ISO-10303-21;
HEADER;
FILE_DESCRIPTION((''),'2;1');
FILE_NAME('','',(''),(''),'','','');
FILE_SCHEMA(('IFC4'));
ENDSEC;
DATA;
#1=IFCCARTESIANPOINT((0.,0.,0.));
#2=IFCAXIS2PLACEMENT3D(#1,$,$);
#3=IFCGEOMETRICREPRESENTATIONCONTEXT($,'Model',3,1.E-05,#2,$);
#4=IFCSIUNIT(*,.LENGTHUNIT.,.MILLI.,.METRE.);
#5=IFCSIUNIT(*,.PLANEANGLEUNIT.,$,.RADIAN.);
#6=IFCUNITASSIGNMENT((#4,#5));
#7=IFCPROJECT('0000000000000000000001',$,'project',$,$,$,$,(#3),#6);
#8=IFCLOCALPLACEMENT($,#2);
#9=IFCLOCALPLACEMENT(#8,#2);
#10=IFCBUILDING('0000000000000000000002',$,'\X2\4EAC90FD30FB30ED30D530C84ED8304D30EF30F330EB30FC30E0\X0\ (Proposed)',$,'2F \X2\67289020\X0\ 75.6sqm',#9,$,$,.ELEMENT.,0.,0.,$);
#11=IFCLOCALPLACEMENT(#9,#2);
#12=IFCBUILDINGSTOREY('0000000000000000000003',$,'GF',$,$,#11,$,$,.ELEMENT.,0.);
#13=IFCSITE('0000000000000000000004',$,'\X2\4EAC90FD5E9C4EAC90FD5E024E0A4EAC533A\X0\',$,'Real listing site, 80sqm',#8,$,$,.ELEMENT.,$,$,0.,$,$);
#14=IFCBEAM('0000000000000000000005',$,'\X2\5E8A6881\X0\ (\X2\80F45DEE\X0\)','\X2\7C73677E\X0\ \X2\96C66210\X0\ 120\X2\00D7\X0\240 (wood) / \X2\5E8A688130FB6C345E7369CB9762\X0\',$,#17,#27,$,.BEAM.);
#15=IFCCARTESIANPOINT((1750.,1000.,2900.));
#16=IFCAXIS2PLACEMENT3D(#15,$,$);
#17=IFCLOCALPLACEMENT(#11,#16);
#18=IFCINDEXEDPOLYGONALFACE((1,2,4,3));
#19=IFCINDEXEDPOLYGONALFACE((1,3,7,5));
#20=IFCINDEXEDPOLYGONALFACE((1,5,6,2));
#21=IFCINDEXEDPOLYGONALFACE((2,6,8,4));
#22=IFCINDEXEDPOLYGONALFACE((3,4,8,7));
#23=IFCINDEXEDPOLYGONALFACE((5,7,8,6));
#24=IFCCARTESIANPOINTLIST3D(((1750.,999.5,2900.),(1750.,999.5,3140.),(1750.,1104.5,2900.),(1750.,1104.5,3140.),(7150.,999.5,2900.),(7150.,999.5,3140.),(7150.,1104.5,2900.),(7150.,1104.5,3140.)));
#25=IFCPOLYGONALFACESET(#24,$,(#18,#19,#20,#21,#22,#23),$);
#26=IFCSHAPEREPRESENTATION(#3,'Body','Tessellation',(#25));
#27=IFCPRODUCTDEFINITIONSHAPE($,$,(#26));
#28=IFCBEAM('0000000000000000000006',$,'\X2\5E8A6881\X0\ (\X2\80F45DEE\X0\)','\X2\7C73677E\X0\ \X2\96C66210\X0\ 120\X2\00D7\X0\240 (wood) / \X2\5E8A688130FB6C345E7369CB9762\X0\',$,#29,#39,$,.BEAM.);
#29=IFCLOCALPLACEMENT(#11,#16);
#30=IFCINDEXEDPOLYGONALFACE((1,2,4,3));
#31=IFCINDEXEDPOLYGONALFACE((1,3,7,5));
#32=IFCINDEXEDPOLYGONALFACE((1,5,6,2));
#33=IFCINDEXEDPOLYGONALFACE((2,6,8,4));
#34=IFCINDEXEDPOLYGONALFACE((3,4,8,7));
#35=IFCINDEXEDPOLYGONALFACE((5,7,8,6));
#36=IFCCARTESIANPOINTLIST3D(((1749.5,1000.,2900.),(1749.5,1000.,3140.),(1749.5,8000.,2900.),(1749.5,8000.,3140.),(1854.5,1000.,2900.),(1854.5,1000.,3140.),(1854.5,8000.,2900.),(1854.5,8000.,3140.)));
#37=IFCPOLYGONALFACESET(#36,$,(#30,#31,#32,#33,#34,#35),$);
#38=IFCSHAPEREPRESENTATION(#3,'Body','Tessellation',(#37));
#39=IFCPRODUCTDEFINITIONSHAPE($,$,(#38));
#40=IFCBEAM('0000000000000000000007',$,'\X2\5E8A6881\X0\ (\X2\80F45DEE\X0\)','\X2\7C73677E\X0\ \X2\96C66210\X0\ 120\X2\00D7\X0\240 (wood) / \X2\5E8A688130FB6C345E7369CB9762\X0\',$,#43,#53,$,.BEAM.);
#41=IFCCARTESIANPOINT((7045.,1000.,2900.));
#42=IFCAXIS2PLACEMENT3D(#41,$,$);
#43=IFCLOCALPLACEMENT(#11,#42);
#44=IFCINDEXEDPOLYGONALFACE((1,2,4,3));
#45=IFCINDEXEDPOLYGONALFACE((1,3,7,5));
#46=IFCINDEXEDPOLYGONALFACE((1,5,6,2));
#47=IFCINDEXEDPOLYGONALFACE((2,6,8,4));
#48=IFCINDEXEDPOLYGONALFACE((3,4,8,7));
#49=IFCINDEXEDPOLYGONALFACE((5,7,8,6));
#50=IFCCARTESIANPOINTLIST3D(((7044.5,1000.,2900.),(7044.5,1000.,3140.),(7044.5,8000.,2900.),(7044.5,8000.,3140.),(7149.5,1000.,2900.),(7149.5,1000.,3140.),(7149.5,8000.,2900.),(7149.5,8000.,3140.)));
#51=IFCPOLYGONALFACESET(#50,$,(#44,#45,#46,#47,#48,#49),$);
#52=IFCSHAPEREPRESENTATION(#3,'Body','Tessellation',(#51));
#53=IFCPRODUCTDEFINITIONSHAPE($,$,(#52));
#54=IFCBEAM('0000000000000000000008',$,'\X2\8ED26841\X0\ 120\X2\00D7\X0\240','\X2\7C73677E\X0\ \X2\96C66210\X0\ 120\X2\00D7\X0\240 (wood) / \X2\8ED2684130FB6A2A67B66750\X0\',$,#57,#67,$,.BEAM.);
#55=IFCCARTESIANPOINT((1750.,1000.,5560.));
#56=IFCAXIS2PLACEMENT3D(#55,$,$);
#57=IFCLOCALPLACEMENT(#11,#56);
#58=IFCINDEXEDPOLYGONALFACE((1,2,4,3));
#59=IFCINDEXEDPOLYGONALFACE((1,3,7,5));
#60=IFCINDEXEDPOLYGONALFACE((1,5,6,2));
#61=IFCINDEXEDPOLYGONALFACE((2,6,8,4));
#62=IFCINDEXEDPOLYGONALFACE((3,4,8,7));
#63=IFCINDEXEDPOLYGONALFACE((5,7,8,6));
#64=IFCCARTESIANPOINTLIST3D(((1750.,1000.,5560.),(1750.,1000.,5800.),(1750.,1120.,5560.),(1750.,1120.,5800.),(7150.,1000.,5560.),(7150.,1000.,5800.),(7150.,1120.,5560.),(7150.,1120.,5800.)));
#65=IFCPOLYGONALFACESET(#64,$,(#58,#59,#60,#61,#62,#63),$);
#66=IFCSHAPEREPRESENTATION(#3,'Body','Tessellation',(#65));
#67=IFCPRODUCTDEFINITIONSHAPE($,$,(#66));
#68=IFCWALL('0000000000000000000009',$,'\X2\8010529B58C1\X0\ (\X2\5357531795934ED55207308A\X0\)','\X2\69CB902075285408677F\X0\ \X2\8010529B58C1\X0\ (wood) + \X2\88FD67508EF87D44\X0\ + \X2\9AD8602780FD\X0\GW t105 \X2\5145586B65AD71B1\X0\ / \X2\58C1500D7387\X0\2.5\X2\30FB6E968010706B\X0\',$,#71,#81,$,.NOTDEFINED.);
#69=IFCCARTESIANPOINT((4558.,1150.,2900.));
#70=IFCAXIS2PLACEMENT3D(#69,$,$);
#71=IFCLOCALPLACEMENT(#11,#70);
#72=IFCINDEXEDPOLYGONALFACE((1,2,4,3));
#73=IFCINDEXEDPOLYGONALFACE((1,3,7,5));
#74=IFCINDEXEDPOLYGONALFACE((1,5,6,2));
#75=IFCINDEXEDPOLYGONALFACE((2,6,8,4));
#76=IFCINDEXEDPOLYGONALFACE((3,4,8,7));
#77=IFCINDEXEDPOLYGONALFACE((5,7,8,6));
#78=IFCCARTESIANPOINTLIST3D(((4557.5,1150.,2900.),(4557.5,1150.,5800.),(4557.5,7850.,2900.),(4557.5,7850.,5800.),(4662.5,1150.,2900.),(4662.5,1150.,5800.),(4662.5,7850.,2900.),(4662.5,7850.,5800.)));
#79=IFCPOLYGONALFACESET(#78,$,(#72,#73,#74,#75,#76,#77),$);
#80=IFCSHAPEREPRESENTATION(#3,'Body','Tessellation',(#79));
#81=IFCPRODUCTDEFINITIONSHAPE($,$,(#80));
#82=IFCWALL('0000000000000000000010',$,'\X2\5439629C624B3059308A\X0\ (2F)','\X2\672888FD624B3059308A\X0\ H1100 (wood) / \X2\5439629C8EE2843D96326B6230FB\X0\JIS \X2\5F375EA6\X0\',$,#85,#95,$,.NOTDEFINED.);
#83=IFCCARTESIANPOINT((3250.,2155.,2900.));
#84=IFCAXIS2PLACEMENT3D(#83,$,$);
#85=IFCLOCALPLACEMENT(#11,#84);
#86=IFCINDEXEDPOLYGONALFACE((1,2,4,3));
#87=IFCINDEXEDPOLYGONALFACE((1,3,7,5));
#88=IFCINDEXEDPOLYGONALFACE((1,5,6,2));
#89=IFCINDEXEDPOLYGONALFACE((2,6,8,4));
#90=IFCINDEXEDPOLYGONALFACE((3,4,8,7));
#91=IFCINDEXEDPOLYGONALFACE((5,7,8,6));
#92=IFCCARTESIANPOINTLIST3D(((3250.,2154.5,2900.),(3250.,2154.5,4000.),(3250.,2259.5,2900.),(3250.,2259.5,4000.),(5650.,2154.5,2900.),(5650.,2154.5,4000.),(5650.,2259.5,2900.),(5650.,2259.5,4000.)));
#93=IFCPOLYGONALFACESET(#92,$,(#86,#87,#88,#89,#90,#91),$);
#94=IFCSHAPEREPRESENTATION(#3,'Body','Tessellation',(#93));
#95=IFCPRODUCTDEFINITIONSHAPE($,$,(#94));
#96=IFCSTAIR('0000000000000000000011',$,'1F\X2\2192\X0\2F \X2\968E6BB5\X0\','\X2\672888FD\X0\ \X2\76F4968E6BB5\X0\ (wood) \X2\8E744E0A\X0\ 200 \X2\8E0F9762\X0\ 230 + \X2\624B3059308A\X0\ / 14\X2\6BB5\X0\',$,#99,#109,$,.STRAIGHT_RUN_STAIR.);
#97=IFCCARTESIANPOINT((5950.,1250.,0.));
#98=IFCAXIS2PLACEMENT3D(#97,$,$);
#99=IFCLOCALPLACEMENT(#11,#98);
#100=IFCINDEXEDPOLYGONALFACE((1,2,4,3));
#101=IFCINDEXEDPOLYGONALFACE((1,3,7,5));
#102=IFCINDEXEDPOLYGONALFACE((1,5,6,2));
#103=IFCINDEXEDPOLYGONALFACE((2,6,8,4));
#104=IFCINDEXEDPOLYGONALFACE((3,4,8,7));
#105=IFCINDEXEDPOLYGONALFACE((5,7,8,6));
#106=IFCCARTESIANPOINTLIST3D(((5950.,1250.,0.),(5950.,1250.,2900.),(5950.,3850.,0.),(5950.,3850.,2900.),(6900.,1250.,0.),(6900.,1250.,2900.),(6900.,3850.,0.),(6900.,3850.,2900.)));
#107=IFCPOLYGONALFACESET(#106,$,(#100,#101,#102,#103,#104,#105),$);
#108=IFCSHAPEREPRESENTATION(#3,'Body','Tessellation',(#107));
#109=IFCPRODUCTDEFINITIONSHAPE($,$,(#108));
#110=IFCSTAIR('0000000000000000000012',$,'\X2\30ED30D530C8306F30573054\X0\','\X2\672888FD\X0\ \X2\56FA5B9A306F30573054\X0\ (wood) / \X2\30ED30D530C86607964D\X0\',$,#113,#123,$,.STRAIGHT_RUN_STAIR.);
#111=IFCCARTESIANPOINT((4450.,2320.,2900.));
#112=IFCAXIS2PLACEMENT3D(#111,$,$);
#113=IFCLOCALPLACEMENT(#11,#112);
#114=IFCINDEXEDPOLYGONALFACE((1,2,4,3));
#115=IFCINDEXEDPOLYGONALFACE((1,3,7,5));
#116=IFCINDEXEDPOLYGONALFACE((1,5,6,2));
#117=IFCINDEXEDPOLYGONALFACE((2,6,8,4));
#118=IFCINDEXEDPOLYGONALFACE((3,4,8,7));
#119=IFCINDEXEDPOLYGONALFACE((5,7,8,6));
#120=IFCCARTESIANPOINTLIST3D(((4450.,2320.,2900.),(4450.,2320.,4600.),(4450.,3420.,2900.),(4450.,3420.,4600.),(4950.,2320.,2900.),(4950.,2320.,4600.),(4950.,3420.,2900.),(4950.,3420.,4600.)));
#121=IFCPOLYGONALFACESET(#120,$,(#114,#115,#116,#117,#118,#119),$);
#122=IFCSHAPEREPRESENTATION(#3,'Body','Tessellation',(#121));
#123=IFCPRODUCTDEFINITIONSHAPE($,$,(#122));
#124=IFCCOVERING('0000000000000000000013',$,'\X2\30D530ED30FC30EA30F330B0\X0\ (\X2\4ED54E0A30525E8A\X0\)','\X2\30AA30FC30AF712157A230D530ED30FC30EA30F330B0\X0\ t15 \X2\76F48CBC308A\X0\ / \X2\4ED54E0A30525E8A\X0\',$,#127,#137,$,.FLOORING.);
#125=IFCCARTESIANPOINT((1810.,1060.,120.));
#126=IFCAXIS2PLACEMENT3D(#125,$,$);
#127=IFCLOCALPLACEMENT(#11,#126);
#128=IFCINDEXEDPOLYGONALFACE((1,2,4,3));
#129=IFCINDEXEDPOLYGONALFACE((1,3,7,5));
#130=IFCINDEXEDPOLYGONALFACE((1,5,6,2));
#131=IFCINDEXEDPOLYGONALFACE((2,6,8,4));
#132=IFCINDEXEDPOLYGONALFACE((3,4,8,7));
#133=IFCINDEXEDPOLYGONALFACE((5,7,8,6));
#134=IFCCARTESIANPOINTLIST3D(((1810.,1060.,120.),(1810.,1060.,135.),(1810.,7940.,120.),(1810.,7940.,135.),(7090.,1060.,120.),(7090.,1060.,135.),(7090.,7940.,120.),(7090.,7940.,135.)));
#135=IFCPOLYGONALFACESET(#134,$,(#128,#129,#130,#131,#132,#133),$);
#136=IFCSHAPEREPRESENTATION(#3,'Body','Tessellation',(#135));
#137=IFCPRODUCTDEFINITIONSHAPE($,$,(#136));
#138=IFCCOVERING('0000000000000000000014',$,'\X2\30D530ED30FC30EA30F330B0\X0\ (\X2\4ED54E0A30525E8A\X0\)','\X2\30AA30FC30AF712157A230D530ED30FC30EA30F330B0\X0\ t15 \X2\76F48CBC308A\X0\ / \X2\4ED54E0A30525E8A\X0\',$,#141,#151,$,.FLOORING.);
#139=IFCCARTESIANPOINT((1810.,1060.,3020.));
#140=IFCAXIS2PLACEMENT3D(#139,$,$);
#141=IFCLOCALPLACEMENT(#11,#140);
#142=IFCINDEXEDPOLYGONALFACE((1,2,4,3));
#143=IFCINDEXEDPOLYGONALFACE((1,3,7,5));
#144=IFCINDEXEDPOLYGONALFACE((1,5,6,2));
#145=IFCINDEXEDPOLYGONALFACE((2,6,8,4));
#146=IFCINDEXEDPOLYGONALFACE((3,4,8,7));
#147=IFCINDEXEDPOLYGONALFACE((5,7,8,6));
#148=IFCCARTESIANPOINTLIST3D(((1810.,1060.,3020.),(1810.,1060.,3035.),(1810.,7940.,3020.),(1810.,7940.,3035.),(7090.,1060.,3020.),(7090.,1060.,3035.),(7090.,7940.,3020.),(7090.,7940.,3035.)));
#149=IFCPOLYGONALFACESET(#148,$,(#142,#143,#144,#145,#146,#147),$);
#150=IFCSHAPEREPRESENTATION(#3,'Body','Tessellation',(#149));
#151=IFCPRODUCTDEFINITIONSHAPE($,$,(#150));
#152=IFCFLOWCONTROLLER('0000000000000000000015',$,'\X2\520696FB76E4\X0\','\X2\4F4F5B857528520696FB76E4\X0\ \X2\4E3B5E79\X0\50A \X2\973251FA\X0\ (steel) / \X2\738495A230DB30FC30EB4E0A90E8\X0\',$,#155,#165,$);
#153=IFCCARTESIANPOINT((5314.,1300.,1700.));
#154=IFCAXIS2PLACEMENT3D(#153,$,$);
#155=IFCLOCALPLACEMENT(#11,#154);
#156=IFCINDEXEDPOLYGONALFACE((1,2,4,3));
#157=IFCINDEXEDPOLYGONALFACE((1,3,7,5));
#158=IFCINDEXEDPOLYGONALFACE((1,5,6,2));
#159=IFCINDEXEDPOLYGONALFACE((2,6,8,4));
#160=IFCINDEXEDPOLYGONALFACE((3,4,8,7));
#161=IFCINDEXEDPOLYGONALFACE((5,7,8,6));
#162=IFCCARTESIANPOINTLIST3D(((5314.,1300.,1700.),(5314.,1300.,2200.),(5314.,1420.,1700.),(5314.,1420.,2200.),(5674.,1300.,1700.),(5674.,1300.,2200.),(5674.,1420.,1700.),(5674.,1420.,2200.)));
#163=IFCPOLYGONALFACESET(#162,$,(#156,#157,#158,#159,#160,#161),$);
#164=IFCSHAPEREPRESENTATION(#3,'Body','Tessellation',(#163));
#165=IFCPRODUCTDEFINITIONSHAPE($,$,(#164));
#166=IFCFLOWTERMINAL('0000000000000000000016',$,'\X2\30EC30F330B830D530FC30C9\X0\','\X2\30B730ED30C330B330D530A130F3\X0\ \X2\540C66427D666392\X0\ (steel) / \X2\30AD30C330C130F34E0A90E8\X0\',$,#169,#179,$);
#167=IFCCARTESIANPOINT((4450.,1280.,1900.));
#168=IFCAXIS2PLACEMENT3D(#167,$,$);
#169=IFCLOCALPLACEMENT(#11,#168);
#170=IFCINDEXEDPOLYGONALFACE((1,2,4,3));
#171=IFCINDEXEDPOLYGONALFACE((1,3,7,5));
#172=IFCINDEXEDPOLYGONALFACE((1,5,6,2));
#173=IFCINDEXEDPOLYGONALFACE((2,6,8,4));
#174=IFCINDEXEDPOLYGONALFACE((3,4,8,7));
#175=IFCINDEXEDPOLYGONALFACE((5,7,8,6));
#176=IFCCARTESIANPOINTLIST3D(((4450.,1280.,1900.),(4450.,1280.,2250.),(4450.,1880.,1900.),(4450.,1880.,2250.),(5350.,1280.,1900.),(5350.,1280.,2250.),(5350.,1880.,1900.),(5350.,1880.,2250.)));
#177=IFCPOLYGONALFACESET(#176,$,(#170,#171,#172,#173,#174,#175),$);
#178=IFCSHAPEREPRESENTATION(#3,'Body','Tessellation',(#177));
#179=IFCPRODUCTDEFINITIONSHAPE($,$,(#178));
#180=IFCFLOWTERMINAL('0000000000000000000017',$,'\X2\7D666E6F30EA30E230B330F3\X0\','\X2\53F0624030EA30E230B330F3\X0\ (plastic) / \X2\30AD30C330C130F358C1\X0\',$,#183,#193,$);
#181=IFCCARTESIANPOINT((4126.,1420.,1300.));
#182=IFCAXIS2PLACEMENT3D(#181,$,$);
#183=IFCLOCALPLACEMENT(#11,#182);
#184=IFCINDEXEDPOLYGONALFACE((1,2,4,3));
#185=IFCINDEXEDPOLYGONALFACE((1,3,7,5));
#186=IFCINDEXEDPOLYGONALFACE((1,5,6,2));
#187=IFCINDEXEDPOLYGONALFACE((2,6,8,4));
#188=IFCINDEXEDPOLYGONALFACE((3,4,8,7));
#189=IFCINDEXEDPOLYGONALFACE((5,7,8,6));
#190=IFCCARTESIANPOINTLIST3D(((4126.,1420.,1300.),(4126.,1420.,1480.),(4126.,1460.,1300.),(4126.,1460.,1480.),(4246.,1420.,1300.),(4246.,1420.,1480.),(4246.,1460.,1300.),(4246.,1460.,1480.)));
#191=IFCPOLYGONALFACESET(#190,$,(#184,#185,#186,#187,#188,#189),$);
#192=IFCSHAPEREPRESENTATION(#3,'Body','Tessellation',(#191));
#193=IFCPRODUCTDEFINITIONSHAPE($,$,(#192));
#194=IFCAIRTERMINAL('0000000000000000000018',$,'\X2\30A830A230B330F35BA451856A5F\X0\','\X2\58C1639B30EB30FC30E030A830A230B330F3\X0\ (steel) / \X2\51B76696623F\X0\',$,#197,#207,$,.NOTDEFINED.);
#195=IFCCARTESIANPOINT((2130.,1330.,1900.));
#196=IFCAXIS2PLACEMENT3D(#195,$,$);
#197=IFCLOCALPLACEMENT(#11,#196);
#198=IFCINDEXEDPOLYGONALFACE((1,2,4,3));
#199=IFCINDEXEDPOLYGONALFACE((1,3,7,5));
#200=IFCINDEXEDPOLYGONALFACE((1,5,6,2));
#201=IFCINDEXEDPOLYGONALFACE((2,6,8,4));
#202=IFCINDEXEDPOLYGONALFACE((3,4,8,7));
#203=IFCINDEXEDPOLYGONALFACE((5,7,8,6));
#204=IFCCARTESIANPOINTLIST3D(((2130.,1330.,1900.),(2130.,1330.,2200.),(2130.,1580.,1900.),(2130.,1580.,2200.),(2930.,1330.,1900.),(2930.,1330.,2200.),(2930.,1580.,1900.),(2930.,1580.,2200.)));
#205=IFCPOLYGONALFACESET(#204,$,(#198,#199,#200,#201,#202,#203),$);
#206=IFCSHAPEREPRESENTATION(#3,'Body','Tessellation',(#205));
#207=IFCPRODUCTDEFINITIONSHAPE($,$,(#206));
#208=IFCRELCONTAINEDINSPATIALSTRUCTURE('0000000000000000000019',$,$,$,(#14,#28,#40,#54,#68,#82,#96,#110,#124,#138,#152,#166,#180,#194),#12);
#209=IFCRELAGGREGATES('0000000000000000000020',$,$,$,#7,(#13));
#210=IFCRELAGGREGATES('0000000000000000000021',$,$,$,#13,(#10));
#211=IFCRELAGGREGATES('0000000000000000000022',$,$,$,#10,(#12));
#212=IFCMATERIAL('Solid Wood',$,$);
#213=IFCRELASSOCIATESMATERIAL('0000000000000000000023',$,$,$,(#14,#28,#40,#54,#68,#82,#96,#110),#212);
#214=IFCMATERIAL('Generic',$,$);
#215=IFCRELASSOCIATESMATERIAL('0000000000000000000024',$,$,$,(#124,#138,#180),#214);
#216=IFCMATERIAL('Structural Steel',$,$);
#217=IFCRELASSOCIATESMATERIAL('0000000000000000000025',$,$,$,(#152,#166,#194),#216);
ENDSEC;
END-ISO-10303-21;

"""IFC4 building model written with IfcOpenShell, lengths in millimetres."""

from ifc_helpers import new_model, si_unit, frame, frame_2d, origin, place, context, project, spatial, rectangle, extrude, material, element, save


model = new_model("IFC4")

# Units and contexts
model_context = context("Model", 3, precision=1e-05, world=origin())
ifc_project = project(units=[si_unit("LENGTHUNIT", "METRE", prefix="MILLI"), si_unit("PLANEANGLEUNIT", "RADIAN")], contexts=[model_context])

# Site, building, storey
site_placement = place(None, origin())
site = spatial("IfcSite", under=ifc_project, at=site_placement, Name="京都府京都市上京区", ObjectType="Real listing site, 80sqm", CompositionType="ELEMENT", RefElevation=0.0)
building_placement = place(site_placement, origin())
building = spatial("IfcBuilding", under=site, at=building_placement, Name="京都・ロフト付きワンルーム (Proposed)", ObjectType="2F 木造 75.6sqm", CompositionType="ELEMENT", ElevationOfRefHeight=0.0, ElevationOfTerrain=0.0)
storey_placement = place(building_placement, origin())
storey = spatial("IfcBuildingStorey", under=building, at=storey_placement, Name="GF", CompositionType="ELEMENT", Elevation=0.0)

# Beams
ifc_material_1 = material(Name="Solid Wood")
beam_1_placement = place(storey_placement, frame((1750.0, 1000.0, 2900.0)))
element("IfcBeam", 1, at=beam_1_placement, inside=storey, material=ifc_material_1, Name="床梁 (胴差)", Description="米松 集成 120×240 (wood) / 床梁・水平構面", PredefinedType="BEAM", context=model_context, shape_type="SweptSolid", body=[
    extrude(rectangle(XDim=5400.0, YDim=105.0, at=frame_2d((2700.0, 52.0))), frame((1750.0, 1000.0, 2900.0)), (0.0, 0.0, 1.0), 240.0),
])
beam_2_placement = place(storey_placement, frame((1750.0, 1000.0, 2900.0)))
element("IfcBeam", 2, at=beam_2_placement, inside=storey, material=ifc_material_1, Name="床梁 (胴差)", Description="米松 集成 120×240 (wood) / 床梁・水平構面", PredefinedType="BEAM", context=model_context, shape_type="SweptSolid", body=[
    extrude(rectangle(XDim=105.0, YDim=7000.0, at=frame_2d((52.0, 3500.0))), frame((1750.0, 1000.0, 2900.0)), (0.0, 0.0, 1.0), 240.0),
])
beam_3_placement = place(storey_placement, frame((7045.0, 1000.0, 2900.0)))
element("IfcBeam", 3, at=beam_3_placement, inside=storey, material=ifc_material_1, Name="床梁 (胴差)", Description="米松 集成 120×240 (wood) / 床梁・水平構面", PredefinedType="BEAM", context=model_context, shape_type="SweptSolid", body=[
    extrude(rectangle(XDim=105.0, YDim=7000.0, at=frame_2d((52.0, 3500.0))), frame((7045.0, 1000.0, 2900.0)), (0.0, 0.0, 1.0), 240.0),
])
beam_4_placement = place(storey_placement, frame((1750.0, 1000.0, 5560.0)))
element("IfcBeam", 4, at=beam_4_placement, inside=storey, material=ifc_material_1, Name="軒桁 120×240", Description="米松 集成 120×240 (wood) / 軒桁・横架材", PredefinedType="BEAM", context=model_context, shape_type="SweptSolid", body=[
    extrude(rectangle(XDim=5400.0, YDim=120.0, at=frame_2d((2700.0, 60.0))), frame((1750.0, 1000.0, 5560.0)), (0.0, 0.0, 1.0), 240.0),
])

# Walls
wall_1_placement = place(storey_placement, frame((4558.0, 1150.0, 2900.0)))
element("IfcWall", 5, at=wall_1_placement, inside=storey, material=ifc_material_1, Name="耐力壁 (南北間仕切り)", Description="構造用合板 耐力壁 (wood) + 製材軸組 + 高性能GW t105 充填断熱 / 壁倍率2.5・準耐火", PredefinedType="NOTDEFINED", context=model_context, shape_type="SweptSolid", body=[
    extrude(rectangle(XDim=105.0, YDim=6700.0, at=frame_2d((52.0, 3350.0))), frame((4558.0, 1150.0, 2900.0)), (0.0, 0.0, 1.0), 2900.0),
])
wall_2_placement = place(storey_placement, frame((3250.0, 2155.0, 2900.0)))
element("IfcWall", 6, at=wall_2_placement, inside=storey, material=ifc_material_1, Name="吹抜手すり (2F)", Description="木製手すり H1100 (wood) / 吹抜転落防止・JIS 強度", PredefinedType="NOTDEFINED", context=model_context, shape_type="SweptSolid", body=[
    extrude(rectangle(XDim=2400.0, YDim=105.0, at=frame_2d((1200.0, 52.0))), frame((3250.0, 2155.0, 2900.0)), (0.0, 0.0, 1.0), 1100.0),
])

# Stairs
stair_1_placement = place(storey_placement, frame((5950.0, 1250.0, 0.0)))
element("IfcStair", 7, at=stair_1_placement, inside=storey, material=ifc_material_1, Name="1F→2F 階段", Description="木製 直階段 (wood) 蹴上 200 踏面 230 + 手すり / 14段", PredefinedType="STRAIGHT_RUN_STAIR", context=model_context, shape_type="SweptSolid", body=[
    extrude(rectangle(XDim=950.0, YDim=2600.0, at=frame_2d((475.0, 1300.0))), frame((5950.0, 1250.0, 0.0)), (0.0, 0.0, 1.0), 2900.0),
])
stair_2_placement = place(storey_placement, frame((4450.0, 2320.0, 2900.0)))
element("IfcStair", 8, at=stair_2_placement, inside=storey, material=ifc_material_1, Name="ロフトはしご", Description="木製 固定はしご (wood) / ロフト昇降", PredefinedType="STRAIGHT_RUN_STAIR", context=model_context, shape_type="SweptSolid", body=[
    extrude(rectangle(XDim=500.0, YDim=1100.0, at=frame_2d((250.0, 550.0))), frame((4450.0, 2320.0, 2900.0)), (0.0, 0.0, 1.0), 1700.0),
])

# Coverings
ifc_material_2 = material(Name="Generic")
covering_1_placement = place(storey_placement, frame((1810.0, 1060.0, 120.0)))
element("IfcCovering", 9, at=covering_1_placement, inside=storey, material=ifc_material_2, Name="フローリング (仕上げ床)", Description="オーク無垢フローリング t15 直貼り / 仕上げ床", PredefinedType="FLOORING", context=model_context, shape_type="SweptSolid", body=[
    extrude(rectangle(XDim=5280.0, YDim=6880.0, at=frame_2d((2640.0, 3440.0))), frame((1810.0, 1060.0, 120.0)), (0.0, 0.0, 1.0), 15.0),
])
covering_2_placement = place(storey_placement, frame((1810.0, 1060.0, 3020.0)))
element("IfcCovering", 10, at=covering_2_placement, inside=storey, material=ifc_material_2, Name="フローリング (仕上げ床)", Description="オーク無垢フローリング t15 直貼り / 仕上げ床", PredefinedType="FLOORING", context=model_context, shape_type="SweptSolid", body=[
    extrude(rectangle(XDim=5280.0, YDim=6880.0, at=frame_2d((2640.0, 3440.0))), frame((1810.0, 1060.0, 3020.0)), (0.0, 0.0, 1.0), 15.0),
])

# Flow controller
ifc_material_3 = material(Name="Structural Steel")
flow_controller_placement = place(storey_placement, frame((5314.0, 1300.0, 1700.0)))
element("IfcFlowController", 11, at=flow_controller_placement, inside=storey, material=ifc_material_3, Name="分電盤", Description="住宅用分電盤 主幹50A 露出 (steel) / 玄関ホール上部", context=model_context, shape_type="SweptSolid", body=[
    extrude(rectangle(XDim=360.0, YDim=120.0, at=frame_2d((180.0, 60.0))), frame((5314.0, 1300.0, 1700.0)), (0.0, 0.0, 1.0), 500.0),
])

# Flow terminals
flow_terminal_1_placement = place(storey_placement, frame((4450.0, 1280.0, 1900.0)))
element("IfcFlowTerminal", 12, at=flow_terminal_1_placement, inside=storey, material=ifc_material_3, Name="レンジフード", Description="シロッコファン 同時給排 (steel) / キッチン上部", context=model_context, shape_type="SweptSolid", body=[
    extrude(rectangle(XDim=900.0, YDim=600.0, at=frame_2d((450.0, 300.0))), frame((4450.0, 1280.0, 1900.0)), (0.0, 0.0, 1.0), 350.0),
])
flow_terminal_2_placement = place(storey_placement, frame((4126.0, 1420.0, 1300.0)))
element("IfcFlowTerminal", 13, at=flow_terminal_2_placement, inside=storey, material=ifc_material_2, Name="給湯リモコン", Description="台所リモコン (plastic) / キッチン壁", context=model_context, shape_type="SweptSolid", body=[
    extrude(rectangle(XDim=120.0, YDim=40.0, at=frame_2d((60.0, 20.0))), frame((4126.0, 1420.0, 1300.0)), (0.0, 0.0, 1.0), 180.0),
])

# Air terminal
air_terminal_1_placement = place(storey_placement, frame((2130.0, 1330.0, 1900.0)))
element("IfcAirTerminal", 14, at=air_terminal_1_placement, inside=storey, material=ifc_material_3, Name="エアコン室内機", Description="壁掛ルームエアコン (steel) / 冷暖房", PredefinedType="NOTDEFINED", context=model_context, shape_type="SweptSolid", body=[
    extrude(rectangle(XDim=800.0, YDim=250.0, at=frame_2d((400.0, 125.0))), frame((2130.0, 1330.0, 1900.0)), (0.0, 0.0, 1.0), 300.0),
])

save(model, "model.ifc")
